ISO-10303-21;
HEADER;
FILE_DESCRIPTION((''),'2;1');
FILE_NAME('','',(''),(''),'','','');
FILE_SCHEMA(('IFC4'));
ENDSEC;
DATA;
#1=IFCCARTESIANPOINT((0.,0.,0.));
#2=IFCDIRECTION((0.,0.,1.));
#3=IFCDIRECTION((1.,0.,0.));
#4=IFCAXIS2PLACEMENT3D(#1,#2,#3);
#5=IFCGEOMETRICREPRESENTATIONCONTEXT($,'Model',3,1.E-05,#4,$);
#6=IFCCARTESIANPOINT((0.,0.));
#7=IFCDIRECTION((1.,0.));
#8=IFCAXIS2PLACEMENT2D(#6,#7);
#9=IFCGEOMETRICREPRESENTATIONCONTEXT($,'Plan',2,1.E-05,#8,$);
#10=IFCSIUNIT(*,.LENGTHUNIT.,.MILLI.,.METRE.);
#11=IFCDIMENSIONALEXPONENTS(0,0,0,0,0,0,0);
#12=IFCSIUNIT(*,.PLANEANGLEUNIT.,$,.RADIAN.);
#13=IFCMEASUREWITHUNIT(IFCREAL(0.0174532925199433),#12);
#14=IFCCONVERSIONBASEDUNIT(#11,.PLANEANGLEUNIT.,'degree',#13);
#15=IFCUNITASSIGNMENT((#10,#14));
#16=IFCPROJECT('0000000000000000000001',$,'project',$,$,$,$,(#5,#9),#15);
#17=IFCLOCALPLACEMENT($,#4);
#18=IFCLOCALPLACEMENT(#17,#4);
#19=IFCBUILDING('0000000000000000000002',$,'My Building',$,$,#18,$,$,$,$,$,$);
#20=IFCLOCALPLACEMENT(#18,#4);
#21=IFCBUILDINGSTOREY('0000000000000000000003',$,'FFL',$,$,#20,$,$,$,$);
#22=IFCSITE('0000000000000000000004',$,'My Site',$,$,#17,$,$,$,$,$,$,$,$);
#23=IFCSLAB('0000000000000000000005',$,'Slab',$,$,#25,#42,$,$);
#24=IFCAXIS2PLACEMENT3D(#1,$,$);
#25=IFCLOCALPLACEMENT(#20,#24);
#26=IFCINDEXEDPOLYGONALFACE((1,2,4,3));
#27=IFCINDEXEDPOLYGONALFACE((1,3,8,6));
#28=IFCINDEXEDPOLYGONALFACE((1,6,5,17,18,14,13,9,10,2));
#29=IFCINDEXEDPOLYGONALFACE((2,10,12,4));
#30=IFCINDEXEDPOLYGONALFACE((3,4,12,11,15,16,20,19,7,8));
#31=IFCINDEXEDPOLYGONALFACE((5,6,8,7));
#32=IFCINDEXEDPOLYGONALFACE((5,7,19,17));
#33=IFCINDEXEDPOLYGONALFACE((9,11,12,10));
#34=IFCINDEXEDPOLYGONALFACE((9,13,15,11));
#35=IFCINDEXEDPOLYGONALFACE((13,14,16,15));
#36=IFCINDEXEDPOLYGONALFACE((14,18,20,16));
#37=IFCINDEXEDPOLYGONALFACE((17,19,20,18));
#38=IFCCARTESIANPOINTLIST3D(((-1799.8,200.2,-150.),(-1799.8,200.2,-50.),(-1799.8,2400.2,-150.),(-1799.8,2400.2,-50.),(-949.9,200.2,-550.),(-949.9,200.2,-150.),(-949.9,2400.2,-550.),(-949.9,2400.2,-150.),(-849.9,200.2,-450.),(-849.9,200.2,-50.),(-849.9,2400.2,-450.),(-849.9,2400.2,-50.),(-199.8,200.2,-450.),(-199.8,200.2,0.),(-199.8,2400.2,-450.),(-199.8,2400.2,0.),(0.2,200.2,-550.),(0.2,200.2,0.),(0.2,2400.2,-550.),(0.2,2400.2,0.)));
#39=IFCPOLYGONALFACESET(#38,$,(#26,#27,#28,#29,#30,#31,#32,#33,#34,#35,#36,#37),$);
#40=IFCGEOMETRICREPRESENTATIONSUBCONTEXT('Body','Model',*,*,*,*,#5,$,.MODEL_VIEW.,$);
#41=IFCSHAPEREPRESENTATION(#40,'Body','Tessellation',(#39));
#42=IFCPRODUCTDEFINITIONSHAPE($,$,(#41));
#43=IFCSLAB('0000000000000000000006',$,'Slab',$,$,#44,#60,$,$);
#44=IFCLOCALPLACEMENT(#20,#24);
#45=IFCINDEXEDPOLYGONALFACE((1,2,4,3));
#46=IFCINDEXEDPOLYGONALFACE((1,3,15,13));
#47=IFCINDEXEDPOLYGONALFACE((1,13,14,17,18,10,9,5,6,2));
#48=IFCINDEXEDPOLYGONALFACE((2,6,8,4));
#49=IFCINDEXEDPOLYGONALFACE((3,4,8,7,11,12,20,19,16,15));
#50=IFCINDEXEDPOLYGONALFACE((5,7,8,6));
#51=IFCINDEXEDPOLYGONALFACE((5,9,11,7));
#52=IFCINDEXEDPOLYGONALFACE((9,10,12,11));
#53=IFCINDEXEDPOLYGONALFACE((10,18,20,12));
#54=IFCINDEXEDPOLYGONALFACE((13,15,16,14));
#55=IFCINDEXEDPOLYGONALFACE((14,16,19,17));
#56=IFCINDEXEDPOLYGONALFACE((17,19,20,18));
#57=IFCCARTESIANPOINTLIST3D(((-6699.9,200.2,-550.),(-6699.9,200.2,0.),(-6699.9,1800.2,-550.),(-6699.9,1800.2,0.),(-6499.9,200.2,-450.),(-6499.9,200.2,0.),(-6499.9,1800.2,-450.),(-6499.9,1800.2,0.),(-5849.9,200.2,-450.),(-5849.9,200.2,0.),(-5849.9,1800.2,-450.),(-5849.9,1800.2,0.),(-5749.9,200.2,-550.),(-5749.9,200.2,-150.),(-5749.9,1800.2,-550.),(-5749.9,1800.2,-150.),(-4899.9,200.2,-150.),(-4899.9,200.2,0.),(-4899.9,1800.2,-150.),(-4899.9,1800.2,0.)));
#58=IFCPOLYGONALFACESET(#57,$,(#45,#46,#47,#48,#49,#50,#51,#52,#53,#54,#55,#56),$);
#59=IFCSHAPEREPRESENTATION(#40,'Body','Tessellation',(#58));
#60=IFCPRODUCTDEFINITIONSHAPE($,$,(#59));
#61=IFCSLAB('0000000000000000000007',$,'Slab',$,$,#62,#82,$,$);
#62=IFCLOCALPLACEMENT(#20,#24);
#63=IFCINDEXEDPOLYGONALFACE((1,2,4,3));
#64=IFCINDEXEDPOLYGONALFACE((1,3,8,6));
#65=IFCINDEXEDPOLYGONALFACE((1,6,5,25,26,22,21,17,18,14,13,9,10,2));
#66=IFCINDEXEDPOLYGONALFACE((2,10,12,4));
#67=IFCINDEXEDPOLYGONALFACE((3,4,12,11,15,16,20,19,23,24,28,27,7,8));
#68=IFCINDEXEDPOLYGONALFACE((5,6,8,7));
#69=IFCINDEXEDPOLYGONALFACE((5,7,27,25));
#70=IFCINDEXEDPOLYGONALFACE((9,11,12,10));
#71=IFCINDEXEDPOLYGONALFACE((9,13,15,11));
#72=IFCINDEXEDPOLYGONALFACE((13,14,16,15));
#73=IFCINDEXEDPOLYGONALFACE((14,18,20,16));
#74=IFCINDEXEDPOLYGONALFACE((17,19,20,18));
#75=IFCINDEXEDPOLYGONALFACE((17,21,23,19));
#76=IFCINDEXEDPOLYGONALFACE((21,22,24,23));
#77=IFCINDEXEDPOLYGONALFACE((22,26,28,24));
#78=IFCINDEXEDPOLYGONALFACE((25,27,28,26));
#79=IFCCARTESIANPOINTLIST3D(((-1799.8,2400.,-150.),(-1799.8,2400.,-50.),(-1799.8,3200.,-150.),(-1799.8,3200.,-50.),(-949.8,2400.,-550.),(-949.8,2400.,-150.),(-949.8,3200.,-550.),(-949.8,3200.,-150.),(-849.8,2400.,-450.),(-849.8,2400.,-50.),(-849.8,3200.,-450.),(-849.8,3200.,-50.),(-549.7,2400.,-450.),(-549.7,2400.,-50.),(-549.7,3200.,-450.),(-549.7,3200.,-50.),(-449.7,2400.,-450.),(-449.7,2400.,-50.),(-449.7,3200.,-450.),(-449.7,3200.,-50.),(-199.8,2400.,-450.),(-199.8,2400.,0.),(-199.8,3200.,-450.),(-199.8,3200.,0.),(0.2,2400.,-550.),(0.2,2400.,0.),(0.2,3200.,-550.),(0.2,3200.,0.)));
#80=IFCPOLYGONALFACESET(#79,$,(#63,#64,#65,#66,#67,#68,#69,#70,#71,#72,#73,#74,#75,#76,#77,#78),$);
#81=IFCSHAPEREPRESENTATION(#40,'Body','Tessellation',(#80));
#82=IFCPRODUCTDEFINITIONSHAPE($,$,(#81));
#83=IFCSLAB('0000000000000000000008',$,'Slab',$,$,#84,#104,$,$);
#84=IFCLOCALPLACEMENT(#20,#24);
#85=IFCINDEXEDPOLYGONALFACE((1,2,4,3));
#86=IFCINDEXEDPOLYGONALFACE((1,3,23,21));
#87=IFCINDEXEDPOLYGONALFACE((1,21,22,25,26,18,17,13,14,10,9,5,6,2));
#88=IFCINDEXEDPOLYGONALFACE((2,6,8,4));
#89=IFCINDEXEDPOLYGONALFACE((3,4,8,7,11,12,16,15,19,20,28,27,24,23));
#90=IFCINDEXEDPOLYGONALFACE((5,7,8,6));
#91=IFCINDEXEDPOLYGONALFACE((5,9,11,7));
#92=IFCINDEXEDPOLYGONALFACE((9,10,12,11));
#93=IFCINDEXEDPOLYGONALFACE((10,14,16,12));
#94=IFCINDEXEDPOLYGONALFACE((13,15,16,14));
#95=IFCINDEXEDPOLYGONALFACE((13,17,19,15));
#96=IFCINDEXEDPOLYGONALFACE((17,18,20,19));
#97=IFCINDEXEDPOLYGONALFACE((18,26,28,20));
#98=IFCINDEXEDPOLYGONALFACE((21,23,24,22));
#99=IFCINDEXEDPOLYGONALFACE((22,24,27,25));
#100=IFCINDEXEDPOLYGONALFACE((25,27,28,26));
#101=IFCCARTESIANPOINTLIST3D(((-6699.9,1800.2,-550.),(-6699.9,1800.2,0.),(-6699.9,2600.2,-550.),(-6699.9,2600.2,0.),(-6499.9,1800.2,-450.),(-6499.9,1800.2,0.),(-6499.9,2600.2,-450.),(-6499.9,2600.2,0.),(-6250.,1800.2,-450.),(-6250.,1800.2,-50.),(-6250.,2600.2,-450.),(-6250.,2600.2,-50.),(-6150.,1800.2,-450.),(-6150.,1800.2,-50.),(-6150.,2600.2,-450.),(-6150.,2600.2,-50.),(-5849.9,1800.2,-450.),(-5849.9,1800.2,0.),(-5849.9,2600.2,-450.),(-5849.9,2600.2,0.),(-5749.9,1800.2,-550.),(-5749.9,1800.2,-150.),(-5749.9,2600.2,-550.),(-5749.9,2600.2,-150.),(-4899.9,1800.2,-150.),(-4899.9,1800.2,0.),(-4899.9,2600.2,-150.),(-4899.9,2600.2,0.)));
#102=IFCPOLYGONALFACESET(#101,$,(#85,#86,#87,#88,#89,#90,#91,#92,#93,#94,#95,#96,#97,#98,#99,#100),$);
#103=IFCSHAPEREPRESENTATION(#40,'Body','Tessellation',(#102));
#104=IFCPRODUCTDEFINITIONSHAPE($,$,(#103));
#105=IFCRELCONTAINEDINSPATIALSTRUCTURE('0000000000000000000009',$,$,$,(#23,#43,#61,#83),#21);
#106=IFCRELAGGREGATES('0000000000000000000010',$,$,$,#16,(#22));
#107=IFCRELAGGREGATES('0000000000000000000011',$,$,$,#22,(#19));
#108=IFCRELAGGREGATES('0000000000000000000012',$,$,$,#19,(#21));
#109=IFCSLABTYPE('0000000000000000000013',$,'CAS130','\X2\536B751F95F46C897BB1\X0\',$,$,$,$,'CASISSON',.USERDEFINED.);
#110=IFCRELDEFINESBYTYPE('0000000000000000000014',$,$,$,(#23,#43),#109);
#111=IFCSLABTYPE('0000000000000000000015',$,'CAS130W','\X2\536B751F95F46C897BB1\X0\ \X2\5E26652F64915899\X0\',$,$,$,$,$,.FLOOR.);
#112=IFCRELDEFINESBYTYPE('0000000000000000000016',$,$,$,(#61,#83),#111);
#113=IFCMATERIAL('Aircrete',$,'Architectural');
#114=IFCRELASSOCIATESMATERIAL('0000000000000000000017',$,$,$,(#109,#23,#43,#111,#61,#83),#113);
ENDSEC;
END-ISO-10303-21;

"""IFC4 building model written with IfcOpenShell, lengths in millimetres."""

from ifc_helpers import new_model, entity, si_unit, converted_unit, frame, origin_with_axes, origin_2d_with_axis, place, context, subcontext, project, spatial, indexed_curve, outline, extrude, material, material_profile, profile_set, profile_usage, type_object, element, save


model = new_model("IFC4")

# Units and contexts
model_context = context("Model", 3, precision=1e-05, world=origin_with_axes())
plan_context = context("Plan", 2, precision=1e-05, world=origin_2d_with_axis())
body_context_1 = subcontext(model_context, "Body", "Model", "MODEL_VIEW")
ifc_project = project(units=[si_unit("LENGTHUNIT", "METRE", prefix="MILLI"), converted_unit("PLANEANGLEUNIT", "degree", entity("IfcReal", 0.0174532925199433), si_unit("PLANEANGLEUNIT", "RADIAN"), dimensions=[0, 0, 0, 0, 0, 0, 0])], contexts=[model_context, plan_context])

# Site, building, storey
site_placement = place(None, origin_with_axes())
site = spatial("IfcSite", under=ifc_project, at=site_placement, Name="My Site")
building_placement = place(site_placement, origin_with_axes())
building = spatial("IfcBuilding", under=site, at=building_placement, Name="My Building")
storey_placement = place(building_placement, origin_with_axes())
storey = spatial("IfcBuildingStorey", under=building, at=storey_placement, Name="FFL")

# Slab, opening
ifc_material_1 = material(Name="Aircrete", Category="Architectural")
ifc_material_profile_1 = material_profile(ifc_material_1, outline(indexed_curve([(850.0, -550.0), (1800.0, -550.0), (1800.0, 0.0), (1600.0, 0.0), (1600.0, -450.0), (950.0, -450.0), (950.0, 0.0), (0.0, 0.0), (0.0, -150.0), (850.0, -150.0), (850.0, -550.0)])))
ifc_profile_set_1 = profile_set([ifc_material_profile_1])
ifc_profile_usage_1 = profile_usage(ifc_profile_set_1)
slab_type_1 = type_object("IfcSlabType", Name="CAS130", Description="卫生间沉箱", ElementType="CASISSON", PredefinedType="USERDEFINED", material=ifc_profile_set_1)
slab_1_placement = place(storey_placement, frame((-1799.8, 2400.2, 0.0), z_axis=(0.0, -1.0, 0.0), x_axis=(1.0, 0.0, 0.0)))
slab_1 = element("IfcSlab", 1, at=slab_1_placement, inside=storey, type_object=slab_type_1, material=ifc_profile_usage_1, Name="Slab", context=body_context_1, shape_type="SweptSolid", body=[
    extrude(outline(indexed_curve([(850.0, -550.0), (1800.0, -550.0), (1800.0, 0.0), (1600.0, 0.0), (1600.0, -450.0), (950.0, -450.0), (950.0, 0.0), (0.0, 0.0), (0.0, -150.0), (850.0, -150.0), (850.0, -550.0)])), origin_with_axes(), (0.0, 0.0, 1.0), 2200.0),
])
opening_1_placement = place(slab_1_placement, frame((0.0, 0.0, 0.0), z_axis=(0.0, 1.0, 0.0), x_axis=(0.0, 0.0, 1.0)))
element("IfcOpeningElement", 2, at=opening_1_placement, cuts=slab_1, PredefinedType="OPENING", context=body_context_1, shape_type="SweptSolid", body=[
    extrude(outline(indexed_curve([(0.0, 950.0), (2200.0, 950.0), (2200.0, 0.0), (0.0, 0.0), (0.0, 950.0)])), frame((0.0, 0.0, -50.0), z_axis=(0.0, 0.0, 1.0), x_axis=(1.0, 0.0, 0.0)), (0.0, 0.0, 1.0), 100.0),
])

# Slab
ifc_profile_usage_2 = profile_usage(ifc_profile_set_1)
slab_2_placement = place(storey_placement, frame((-4899.9, 200.2, 0.0), z_axis=(0.0, 1.0, 0.0), x_axis=(-1.0, 0.0, 0.0)))
element("IfcSlab", 3, at=slab_2_placement, inside=storey, type_object=slab_type_1, material=ifc_profile_usage_2, Name="Slab", context=body_context_1, shape_type="SweptSolid", body=[
    extrude(outline(indexed_curve([(850.0, -550.0), (1800.0, -550.0), (1800.0, 0.0), (1600.0, 0.0), (1600.0, -450.0), (950.0, -450.0), (950.0, 0.0), (0.0, 0.0), (0.0, -150.0), (850.0, -150.0), (850.0, -550.0)])), origin_with_axes(), (0.0, 0.0, 1.0), 1600.0),
])

# Slab, opening
ifc_material_profile_2 = material_profile(ifc_material_1, outline(indexed_curve([(850.0, -150.0), (0.0, -150.0), (0.0, 0.0), (950.0, 0.0), (950.0, -450.0), (1250.1, -450.0), (1250.1, -50.0), (1350.1, -50.0), (1350.1, -450.0), (1600.0, -450.0), (1600.0, 0.0), (1800.0, 0.0), (1800.0, -550.0), (850.0, -550.0), (850.0, -150.0)])))
ifc_profile_set_2 = profile_set([ifc_material_profile_2])
ifc_profile_usage_3 = profile_usage(ifc_profile_set_2)
slab_type_2 = type_object("IfcSlabType", Name="CAS130W", Description="卫生间沉箱 带支撑墙", PredefinedType="FLOOR", material=ifc_profile_set_2)
slab_3_placement = place(storey_placement, frame((-1799.8, 3200.0, 0.0), z_axis=(0.0, -1.0, 0.0), x_axis=(1.0, 0.0, 0.0)))
slab_3 = element("IfcSlab", 4, at=slab_3_placement, inside=storey, type_object=slab_type_2, material=ifc_profile_usage_3, Name="Slab", context=body_context_1, shape_type="SweptSolid", body=[
    extrude(outline(indexed_curve([(850.0, -150.0), (0.0, -150.0), (0.0, 0.0), (950.0, 0.0), (950.0, -450.0), (1250.1, -450.0), (1250.1, -50.0), (1350.1, -50.0), (1350.1, -450.0), (1600.0, -450.0), (1600.0, 0.0), (1800.0, 0.0), (1800.0, -550.0), (850.0, -550.0), (850.0, -150.0)])), origin_with_axes(), (0.0, 0.0, 1.0), 800.0),
])
opening_2_placement = place(slab_3_placement, frame((0.0, -50.0, 0.0), z_axis=(0.0, 1.0, 0.0), x_axis=(0.0, 0.0, 1.0)))
element("IfcOpeningElement", 5, at=opening_2_placement, cuts=slab_3, PredefinedType="OPENING", context=body_context_1, shape_type="SweptSolid", body=[
    extrude(outline(indexed_curve([(0.0, 950.0), (899.8, 950.0), (899.8, 0.0), (0.0, 0.0), (0.0, 950.0)])), origin_with_axes(), (0.0, 0.0, 1.0), 100.0),
])

# Slab
ifc_profile_usage_4 = profile_usage(ifc_profile_set_2)
slab_4_placement = place(storey_placement, frame((-4899.9, 1800.2, 0.0), z_axis=(0.0, 1.0, 0.0), x_axis=(-1.0, 0.0, 0.0)))
element("IfcSlab", 6, at=slab_4_placement, inside=storey, type_object=slab_type_2, material=ifc_profile_usage_4, Name="Slab", context=body_context_1, shape_type="SweptSolid", body=[
    extrude(outline(indexed_curve([(850.0, -150.0), (0.0, -150.0), (0.0, 0.0), (950.0, 0.0), (950.0, -450.0), (1250.1, -450.0), (1250.1, -50.0), (1350.1, -50.0), (1350.1, -450.0), (1600.0, -450.0), (1600.0, 0.0), (1800.0, 0.0), (1800.0, -550.0), (850.0, -550.0), (850.0, -150.0)])), origin_with_axes(), (0.0, 0.0, 1.0), 800.0),
])

save(model, "model.ifc")
